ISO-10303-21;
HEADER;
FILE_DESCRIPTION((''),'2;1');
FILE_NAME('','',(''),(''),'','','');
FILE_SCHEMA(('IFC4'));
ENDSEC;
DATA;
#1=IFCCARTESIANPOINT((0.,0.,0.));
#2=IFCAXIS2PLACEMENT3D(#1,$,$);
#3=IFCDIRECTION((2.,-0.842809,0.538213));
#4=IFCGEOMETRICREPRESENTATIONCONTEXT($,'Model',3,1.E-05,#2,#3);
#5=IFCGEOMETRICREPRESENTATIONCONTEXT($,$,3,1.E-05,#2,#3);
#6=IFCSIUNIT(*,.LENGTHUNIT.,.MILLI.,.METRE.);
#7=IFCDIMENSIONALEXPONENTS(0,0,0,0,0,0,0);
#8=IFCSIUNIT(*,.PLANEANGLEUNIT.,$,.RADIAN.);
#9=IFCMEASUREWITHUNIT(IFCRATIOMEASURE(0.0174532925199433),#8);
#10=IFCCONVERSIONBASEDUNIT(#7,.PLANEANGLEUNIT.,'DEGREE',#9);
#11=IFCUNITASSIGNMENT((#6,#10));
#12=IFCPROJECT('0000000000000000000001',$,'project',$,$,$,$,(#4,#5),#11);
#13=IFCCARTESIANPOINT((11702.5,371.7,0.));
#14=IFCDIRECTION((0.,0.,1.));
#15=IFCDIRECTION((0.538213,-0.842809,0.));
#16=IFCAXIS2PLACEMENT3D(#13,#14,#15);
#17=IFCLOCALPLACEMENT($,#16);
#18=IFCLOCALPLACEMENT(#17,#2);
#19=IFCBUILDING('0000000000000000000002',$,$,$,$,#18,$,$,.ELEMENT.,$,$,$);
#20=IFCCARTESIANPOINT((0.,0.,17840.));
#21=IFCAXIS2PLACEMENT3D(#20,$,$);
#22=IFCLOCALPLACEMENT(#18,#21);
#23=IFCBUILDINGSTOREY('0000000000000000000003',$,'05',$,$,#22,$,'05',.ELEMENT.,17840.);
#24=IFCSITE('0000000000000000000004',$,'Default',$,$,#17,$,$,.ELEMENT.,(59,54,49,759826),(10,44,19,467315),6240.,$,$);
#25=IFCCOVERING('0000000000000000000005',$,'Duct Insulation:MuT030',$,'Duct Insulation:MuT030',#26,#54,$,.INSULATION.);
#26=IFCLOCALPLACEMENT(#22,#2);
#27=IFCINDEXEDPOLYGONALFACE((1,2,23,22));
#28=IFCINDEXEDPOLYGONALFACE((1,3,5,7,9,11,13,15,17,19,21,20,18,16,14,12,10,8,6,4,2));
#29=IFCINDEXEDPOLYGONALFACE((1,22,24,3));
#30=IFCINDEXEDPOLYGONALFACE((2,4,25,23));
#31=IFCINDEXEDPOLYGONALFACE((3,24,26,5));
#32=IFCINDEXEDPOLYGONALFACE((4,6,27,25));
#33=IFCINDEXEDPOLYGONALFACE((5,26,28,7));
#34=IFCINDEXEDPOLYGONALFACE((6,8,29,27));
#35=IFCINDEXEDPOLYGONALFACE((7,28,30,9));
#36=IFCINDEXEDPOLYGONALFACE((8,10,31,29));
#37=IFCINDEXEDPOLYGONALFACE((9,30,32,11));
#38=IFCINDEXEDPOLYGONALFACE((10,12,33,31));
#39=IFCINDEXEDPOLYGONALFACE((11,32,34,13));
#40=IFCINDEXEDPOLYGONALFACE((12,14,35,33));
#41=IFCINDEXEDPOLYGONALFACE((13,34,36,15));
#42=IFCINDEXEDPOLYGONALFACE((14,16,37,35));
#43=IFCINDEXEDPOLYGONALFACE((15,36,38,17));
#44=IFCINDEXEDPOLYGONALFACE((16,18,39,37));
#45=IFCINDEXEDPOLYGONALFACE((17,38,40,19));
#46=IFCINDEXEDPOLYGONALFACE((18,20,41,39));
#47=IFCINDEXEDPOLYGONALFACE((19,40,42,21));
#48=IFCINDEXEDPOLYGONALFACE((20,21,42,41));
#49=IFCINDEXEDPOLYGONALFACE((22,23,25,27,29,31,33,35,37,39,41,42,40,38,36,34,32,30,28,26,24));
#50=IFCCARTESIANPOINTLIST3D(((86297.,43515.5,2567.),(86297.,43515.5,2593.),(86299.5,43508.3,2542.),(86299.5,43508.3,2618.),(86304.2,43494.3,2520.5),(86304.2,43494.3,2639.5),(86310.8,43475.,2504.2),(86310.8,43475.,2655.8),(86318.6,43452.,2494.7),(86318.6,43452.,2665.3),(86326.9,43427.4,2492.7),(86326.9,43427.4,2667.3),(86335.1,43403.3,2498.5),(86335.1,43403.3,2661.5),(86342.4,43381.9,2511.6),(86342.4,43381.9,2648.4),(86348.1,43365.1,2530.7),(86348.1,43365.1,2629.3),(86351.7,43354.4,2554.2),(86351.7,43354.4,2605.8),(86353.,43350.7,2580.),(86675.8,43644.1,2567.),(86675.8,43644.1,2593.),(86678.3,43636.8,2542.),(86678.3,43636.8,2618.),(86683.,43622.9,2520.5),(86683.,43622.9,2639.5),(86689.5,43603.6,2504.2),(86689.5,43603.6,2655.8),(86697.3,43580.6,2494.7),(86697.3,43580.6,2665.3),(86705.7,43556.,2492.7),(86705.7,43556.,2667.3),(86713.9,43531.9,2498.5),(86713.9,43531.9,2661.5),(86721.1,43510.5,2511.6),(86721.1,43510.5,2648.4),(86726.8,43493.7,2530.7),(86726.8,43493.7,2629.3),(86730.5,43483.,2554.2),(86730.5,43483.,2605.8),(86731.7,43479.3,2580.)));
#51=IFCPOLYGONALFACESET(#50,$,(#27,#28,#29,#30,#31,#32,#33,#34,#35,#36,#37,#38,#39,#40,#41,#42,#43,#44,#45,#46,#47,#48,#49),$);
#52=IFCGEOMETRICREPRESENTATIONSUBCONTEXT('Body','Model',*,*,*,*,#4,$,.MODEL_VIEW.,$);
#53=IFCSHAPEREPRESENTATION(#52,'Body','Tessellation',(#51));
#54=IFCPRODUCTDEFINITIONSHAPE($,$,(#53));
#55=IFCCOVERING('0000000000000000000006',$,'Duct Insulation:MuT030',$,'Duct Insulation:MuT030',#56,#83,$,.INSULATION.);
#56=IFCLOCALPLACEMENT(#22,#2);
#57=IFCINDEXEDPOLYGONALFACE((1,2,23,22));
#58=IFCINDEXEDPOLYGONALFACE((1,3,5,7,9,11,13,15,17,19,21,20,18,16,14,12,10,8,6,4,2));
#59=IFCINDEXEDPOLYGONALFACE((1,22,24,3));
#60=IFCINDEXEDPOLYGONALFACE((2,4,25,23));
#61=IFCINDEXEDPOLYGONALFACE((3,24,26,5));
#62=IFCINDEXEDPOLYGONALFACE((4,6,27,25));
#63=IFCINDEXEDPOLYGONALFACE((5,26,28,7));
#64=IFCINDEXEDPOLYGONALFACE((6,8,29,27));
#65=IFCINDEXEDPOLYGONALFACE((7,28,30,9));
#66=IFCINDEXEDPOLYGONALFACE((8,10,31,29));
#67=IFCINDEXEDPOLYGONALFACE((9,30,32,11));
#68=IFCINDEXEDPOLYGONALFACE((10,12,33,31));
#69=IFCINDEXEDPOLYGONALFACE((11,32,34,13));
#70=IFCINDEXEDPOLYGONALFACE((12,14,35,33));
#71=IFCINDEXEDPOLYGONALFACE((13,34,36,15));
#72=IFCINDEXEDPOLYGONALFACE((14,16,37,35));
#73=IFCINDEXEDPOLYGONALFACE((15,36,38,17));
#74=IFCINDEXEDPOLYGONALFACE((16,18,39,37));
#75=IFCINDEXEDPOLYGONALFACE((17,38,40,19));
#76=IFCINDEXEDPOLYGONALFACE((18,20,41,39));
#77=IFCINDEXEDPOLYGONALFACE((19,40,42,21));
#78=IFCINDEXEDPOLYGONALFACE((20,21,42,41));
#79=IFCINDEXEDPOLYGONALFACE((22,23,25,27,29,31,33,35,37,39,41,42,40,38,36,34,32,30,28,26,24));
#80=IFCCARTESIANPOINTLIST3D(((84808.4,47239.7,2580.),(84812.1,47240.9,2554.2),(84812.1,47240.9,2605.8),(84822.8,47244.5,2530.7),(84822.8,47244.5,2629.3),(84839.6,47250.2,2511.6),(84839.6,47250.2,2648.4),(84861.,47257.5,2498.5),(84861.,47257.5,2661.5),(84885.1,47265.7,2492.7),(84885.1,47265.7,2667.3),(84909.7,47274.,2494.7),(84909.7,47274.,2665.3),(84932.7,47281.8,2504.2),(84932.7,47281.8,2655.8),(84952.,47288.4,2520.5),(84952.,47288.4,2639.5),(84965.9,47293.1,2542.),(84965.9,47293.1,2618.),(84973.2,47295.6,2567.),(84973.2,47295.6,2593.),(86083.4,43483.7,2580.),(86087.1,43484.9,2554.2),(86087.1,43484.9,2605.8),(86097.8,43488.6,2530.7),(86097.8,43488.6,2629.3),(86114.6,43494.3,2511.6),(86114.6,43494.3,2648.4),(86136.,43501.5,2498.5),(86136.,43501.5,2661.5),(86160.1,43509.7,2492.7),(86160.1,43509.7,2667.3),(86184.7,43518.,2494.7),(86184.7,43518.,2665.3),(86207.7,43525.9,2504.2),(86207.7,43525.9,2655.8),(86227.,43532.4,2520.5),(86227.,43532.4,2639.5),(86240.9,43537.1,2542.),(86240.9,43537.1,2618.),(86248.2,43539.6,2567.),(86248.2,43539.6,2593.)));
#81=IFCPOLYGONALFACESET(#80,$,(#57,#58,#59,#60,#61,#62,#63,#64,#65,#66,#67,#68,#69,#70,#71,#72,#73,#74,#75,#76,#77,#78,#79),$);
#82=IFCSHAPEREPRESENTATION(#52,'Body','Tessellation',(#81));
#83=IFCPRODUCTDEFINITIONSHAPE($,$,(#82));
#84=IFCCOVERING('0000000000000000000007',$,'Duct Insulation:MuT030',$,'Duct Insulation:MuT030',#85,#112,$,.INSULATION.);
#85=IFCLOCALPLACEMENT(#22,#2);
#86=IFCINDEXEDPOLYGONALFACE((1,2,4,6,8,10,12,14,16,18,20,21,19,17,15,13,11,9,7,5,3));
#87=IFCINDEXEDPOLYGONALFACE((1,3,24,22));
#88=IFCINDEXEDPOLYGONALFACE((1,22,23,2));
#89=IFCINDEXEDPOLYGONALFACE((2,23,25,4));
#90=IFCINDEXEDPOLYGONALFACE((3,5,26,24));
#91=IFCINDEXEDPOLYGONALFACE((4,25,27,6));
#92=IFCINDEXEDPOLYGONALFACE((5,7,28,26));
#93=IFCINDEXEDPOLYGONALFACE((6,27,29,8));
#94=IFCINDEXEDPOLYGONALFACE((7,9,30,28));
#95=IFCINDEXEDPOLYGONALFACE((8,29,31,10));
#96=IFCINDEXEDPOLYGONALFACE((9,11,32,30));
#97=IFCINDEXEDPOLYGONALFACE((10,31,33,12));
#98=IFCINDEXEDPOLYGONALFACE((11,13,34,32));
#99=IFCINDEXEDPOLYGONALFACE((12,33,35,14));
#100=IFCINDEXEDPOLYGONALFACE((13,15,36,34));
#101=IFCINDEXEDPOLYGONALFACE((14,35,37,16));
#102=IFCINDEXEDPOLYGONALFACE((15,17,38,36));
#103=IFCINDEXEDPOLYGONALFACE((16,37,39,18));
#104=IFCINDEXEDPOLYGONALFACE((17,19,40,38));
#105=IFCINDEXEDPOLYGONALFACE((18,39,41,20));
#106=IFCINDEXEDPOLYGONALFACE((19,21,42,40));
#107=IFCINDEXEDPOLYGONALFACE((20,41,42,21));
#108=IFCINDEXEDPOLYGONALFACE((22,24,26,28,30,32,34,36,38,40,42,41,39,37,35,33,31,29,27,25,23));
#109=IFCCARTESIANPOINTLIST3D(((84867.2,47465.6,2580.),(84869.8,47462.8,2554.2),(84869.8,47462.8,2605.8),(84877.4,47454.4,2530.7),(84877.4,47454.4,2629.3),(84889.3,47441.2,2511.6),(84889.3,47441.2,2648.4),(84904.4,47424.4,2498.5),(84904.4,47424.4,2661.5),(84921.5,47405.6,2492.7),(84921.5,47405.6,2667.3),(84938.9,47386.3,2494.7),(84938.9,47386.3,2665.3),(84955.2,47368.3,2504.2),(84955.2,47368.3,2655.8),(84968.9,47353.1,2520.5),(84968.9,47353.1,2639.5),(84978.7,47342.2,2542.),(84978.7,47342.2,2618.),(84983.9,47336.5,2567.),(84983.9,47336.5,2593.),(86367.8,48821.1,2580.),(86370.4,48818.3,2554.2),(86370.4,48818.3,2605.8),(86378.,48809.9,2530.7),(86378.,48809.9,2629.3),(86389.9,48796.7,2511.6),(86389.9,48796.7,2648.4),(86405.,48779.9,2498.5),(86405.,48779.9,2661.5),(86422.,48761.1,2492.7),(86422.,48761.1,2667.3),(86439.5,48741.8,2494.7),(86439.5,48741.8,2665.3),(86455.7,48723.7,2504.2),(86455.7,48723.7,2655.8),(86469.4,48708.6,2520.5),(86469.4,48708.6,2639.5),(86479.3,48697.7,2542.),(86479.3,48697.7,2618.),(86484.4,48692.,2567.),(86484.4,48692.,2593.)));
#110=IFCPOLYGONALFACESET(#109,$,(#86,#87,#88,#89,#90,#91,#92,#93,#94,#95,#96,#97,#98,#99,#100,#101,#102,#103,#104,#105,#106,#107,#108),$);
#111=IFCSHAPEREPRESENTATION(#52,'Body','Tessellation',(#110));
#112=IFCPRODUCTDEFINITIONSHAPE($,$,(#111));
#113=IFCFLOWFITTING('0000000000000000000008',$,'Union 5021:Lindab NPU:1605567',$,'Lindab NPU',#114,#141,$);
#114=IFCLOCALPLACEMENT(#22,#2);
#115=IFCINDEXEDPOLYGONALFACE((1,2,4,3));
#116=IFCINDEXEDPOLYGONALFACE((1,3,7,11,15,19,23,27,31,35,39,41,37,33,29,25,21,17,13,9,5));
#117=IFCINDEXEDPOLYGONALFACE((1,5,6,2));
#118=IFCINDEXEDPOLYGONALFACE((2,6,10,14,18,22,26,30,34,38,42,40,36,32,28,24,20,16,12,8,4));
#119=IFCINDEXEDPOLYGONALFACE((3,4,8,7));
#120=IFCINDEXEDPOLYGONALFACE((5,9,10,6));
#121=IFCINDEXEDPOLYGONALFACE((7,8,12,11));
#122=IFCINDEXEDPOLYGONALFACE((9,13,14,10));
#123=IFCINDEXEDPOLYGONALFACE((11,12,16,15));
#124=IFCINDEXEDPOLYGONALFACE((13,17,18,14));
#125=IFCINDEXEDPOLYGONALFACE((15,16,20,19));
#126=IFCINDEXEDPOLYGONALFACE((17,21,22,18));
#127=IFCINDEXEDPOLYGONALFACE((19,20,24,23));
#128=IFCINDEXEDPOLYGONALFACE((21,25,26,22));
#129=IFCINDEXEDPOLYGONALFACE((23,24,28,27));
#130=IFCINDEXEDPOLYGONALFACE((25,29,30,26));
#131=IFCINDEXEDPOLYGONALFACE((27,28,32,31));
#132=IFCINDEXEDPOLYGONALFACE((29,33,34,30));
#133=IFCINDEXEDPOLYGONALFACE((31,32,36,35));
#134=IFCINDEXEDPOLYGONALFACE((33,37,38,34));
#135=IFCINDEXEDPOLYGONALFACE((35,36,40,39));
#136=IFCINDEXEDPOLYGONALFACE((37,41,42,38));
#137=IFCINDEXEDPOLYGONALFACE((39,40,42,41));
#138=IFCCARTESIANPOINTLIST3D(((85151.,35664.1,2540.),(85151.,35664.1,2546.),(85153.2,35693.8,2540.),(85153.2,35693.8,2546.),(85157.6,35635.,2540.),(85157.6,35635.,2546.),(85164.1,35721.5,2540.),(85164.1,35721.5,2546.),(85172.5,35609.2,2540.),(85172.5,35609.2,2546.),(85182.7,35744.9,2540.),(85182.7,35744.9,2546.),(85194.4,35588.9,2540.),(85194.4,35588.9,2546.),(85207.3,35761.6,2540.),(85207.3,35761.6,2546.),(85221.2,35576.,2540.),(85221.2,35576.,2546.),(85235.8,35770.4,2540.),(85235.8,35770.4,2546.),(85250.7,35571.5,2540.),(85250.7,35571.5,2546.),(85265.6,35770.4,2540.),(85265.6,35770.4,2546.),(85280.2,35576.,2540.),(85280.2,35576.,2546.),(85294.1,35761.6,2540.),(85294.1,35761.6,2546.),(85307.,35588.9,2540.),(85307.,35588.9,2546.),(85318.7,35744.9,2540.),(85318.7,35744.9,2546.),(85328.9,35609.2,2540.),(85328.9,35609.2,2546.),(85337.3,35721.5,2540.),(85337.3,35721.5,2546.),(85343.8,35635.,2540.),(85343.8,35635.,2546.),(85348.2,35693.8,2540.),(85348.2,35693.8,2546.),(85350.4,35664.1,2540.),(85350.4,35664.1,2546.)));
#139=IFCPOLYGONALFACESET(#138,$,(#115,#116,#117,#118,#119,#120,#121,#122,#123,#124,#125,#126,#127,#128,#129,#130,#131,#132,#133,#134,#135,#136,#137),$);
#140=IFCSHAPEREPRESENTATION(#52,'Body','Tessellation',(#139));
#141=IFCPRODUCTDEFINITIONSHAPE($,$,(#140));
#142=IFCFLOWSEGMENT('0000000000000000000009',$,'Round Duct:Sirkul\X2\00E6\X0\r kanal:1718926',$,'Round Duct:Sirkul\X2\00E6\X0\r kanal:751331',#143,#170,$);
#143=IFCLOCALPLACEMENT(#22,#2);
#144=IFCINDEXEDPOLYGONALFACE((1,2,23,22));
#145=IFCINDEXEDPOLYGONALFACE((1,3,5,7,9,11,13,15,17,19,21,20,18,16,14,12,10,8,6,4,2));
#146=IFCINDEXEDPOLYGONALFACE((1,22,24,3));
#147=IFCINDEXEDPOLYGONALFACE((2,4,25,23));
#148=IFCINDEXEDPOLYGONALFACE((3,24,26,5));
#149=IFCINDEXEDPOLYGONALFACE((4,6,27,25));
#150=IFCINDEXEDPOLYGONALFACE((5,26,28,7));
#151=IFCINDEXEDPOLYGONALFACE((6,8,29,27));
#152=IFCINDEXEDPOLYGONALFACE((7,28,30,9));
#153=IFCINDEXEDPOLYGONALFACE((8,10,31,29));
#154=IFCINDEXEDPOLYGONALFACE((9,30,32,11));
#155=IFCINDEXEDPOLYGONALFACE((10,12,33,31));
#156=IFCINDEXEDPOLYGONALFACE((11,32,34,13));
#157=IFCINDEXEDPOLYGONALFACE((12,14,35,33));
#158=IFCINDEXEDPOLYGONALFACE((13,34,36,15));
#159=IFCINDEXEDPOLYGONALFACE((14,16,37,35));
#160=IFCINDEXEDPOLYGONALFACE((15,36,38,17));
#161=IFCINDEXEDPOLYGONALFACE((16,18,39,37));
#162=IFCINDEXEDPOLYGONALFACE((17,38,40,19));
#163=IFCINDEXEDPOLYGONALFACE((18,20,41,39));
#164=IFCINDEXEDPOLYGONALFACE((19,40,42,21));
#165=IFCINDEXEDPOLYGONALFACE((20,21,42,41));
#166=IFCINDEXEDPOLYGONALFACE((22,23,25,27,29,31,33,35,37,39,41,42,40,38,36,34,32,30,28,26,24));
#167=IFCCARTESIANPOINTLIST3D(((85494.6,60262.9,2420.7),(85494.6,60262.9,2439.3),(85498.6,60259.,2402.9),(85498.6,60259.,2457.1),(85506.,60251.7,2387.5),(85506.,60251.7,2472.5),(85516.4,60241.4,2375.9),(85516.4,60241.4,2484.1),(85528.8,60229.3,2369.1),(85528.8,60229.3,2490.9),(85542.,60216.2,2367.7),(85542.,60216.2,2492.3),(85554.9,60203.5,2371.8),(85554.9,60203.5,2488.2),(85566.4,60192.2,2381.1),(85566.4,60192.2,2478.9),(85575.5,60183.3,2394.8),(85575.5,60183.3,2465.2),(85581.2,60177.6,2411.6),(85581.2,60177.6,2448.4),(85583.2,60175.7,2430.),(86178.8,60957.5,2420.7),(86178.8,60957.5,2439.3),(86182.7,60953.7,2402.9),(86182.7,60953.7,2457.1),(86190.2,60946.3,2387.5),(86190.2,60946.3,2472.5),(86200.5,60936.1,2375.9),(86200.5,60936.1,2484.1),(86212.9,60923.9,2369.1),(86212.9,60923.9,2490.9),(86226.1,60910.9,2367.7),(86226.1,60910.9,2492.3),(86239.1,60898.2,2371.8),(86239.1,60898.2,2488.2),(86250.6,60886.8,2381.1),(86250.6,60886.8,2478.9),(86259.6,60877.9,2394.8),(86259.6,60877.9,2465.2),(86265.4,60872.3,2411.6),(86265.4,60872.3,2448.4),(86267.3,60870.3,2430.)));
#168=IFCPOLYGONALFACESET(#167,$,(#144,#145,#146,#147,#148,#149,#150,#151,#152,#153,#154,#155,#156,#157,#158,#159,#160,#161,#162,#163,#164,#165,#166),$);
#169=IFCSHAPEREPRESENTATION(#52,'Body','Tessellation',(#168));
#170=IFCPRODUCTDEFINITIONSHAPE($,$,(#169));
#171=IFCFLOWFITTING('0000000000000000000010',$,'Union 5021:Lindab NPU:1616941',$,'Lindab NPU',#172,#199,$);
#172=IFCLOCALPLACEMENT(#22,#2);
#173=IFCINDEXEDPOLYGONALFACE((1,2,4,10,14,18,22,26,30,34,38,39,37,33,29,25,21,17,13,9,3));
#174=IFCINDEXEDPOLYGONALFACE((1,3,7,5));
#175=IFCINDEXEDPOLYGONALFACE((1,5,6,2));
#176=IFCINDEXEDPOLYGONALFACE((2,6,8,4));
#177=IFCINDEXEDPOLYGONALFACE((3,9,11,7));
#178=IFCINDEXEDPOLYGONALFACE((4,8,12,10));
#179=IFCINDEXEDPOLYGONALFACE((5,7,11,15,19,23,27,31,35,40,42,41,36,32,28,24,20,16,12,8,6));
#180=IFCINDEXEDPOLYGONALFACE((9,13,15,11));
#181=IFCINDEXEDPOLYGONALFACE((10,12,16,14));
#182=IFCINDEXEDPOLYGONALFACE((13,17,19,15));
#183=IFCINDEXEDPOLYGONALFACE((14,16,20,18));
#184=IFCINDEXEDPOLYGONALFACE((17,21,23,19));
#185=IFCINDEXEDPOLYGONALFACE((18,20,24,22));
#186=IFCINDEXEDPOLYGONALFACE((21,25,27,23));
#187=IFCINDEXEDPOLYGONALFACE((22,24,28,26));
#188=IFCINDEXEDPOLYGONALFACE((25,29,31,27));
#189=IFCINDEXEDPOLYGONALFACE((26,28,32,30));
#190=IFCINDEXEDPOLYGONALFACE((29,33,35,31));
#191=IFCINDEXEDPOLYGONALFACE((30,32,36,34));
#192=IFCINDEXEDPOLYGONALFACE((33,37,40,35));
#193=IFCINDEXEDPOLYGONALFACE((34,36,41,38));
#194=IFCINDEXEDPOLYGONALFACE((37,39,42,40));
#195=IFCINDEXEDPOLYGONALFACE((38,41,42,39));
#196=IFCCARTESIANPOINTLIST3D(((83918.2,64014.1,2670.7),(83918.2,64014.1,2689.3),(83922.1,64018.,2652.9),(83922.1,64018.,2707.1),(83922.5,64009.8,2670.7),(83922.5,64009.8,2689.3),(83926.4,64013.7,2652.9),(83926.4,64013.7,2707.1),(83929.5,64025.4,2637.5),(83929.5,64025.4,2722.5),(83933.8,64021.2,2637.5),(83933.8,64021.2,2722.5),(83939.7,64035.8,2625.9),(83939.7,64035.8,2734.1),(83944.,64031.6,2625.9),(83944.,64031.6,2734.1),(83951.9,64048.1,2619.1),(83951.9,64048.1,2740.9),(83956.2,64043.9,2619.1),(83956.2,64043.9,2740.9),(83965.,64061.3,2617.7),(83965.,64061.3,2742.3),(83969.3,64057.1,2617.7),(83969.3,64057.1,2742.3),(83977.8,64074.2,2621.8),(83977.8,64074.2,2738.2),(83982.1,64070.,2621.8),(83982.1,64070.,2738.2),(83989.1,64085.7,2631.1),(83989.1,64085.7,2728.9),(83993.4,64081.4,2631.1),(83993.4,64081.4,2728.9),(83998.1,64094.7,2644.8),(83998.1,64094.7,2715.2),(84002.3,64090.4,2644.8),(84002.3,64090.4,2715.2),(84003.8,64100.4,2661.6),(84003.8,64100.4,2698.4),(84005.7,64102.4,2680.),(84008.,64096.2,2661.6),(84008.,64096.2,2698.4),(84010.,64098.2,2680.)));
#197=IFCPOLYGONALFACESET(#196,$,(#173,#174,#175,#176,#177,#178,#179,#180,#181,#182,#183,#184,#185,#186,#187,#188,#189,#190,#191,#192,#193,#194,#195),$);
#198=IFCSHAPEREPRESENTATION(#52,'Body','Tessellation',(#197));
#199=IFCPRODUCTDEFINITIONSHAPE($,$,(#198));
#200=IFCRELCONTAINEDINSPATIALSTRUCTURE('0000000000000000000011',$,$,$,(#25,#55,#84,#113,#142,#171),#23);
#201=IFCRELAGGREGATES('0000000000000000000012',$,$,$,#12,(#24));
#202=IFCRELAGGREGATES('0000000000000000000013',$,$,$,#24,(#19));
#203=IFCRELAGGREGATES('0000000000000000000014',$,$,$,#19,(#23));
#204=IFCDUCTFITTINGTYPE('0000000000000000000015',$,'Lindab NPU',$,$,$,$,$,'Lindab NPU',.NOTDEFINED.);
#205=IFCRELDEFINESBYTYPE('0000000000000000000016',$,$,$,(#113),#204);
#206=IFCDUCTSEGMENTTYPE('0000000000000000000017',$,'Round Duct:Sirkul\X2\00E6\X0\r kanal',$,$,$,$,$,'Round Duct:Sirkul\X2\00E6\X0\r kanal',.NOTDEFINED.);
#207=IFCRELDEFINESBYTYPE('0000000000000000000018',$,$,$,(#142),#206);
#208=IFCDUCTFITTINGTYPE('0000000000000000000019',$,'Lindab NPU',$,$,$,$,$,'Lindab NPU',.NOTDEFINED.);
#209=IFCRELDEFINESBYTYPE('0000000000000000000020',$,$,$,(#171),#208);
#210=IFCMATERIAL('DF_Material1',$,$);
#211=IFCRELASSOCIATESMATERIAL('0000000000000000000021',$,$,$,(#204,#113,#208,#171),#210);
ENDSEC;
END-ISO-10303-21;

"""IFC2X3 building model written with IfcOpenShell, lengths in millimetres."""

from ifc_helpers import new_model, entity, si_unit, converted_unit, direction, frame, frame_2d, origin, origin_2d_with_axis, place, context, subcontext, project, spatial, circle, extrude, source, transform, mapped, material, type_object, type_shapes, element, save


model = new_model("IFC2X3")

# Units and contexts
model_context = context("Model", 3, precision=1e-05, world=origin(), true_north=direction((2.0, -0.842809, 0.538213)))
context_of_model = context(None, 3, precision=1e-05, world=origin(), true_north=direction((2.0, -0.842809, 0.538213)))
body_context = subcontext(model_context, "Body", "Model", "MODEL_VIEW")
ifc_project = project(units=[si_unit("LENGTHUNIT", "METRE", prefix="MILLI"), converted_unit("PLANEANGLEUNIT", "DEGREE", entity("IfcRatioMeasure", 0.0174532925199433), si_unit("PLANEANGLEUNIT", "RADIAN"), dimensions=[0, 0, 0, 0, 0, 0, 0])], contexts=[model_context, context_of_model])

# Site, building, storey
site_placement = place(None, frame((11702.5, 371.7, 0.0), z_axis=(0.0, 0.0, 1.0), x_axis=(0.538213, -0.842809, 0.0)))
site = spatial("IfcSite", under=ifc_project, at=site_placement, Name="Default", CompositionType="ELEMENT", RefLatitude=(59, 54, 49, 759826), RefLongitude=(10, 44, 19, 467315), RefElevation=6240.0)
building_placement = place(site_placement, origin())
building = spatial("IfcBuilding", under=site, at=building_placement, CompositionType="ELEMENT")
storey_placement = place(building_placement, frame((0.0, 0.0, 17840.0)))
storey = spatial("IfcBuildingStorey", under=building, at=storey_placement, Name="05", LongName="05", CompositionType="ELEMENT", Elevation=17840.0)

# Coverings
covering_1_placement = place(storey_placement, origin())
element("IfcCovering", 1, at=covering_1_placement, inside=storey, Name="Duct Insulation:MuT030", ObjectType="Duct Insulation:MuT030", PredefinedType="INSULATION", context=body_context, shape_type="SweptSolid", body=[
    extrude(circle(Radius=87.5, at=origin_2d_with_axis()), frame((86324.8, 43433.6, 2580.0), z_axis=(0.94693, 0.321439, 0.0), x_axis=(0.321439, -0.94693, 0.0)), (0.0, 0.0, 1.0), 400.0),
])
covering_2_placement = place(storey_placement, origin())
element("IfcCovering", 2, at=covering_2_placement, inside=storey, Name="Duct Insulation:MuT030", ObjectType="Duct Insulation:MuT030", PredefinedType="INSULATION", context=body_context, shape_type="SweptSolid", body=[
    extrude(circle(Radius=87.5, at=origin_2d_with_axis()), frame((86166.3, 43511.8, 2580.0), z_axis=(-0.321439, 0.94693, 0.0), x_axis=(-0.94693, -0.321439, 0.0)), (0.0, 0.0, 1.0), 3966.5),
])
covering_3_placement = place(storey_placement, origin())
element("IfcCovering", 3, at=covering_3_placement, inside=storey, Name="Duct Insulation:MuT030", ObjectType="Duct Insulation:MuT030", PredefinedType="INSULATION", context=body_context, shape_type="SweptSolid", body=[
    extrude(circle(Radius=87.5, at=origin_2d_with_axis()), frame((84925.9, 47400.7, 2580.0), z_axis=(0.742063, 0.67033, 0.0), x_axis=(-0.67033, 0.742063, 0.0)), (0.0, 0.0, 1.0), 2022.1),
])

# Flow fitting
ifc_material = material(Name="DF_Material1")
duct_fitting_type_1 = type_object("IfcDuctFittingType", Name="Lindab NPU", ElementType="Lindab NPU", PredefinedType="NOTDEFINED", material=ifc_material)
shared_shape_1 = source(origin(), body_context, "Body", "SweptSolid", [
    extrude(circle(Radius=100.0, at=frame_2d((0.0, 0.0), x_axis=(1.0, 0.0))), frame((0.0, 0.0, 0.0), z_axis=(1.0, 0.0, 0.0), x_axis=(0.0, 1.0, 0.0)), (0.0, 0.0, 1.0), 6.0),
])
type_shapes(duct_fitting_type_1, [shared_shape_1])
flow_fitting_placement = place(storey_placement, frame((85250.7, 35671.5, 2540.0), z_axis=(1.0, 0.0, 0.0), x_axis=(0.0, 0.0, 1.0)))
element("IfcFlowFitting", 4, at=flow_fitting_placement, inside=storey, type_object=duct_fitting_type_1, material=ifc_material, Name="Union 5021:Lindab NPU:1605567", ObjectType="Lindab NPU", context=body_context, shape_type="MappedRepresentation", body=[
    mapped(shared_shape_1, transform((0.0, 0.0, 0.0), scale=1.0)),
])

# Flow segment
duct_segment_type = type_object("IfcDuctSegmentType", Name="Round Duct:Sirkulær kanal", ElementType="Round Duct:Sirkulær kanal", PredefinedType="NOTDEFINED")
flow_segment_1_placement = place(storey_placement, origin())
element("IfcFlowSegment", 5, at=flow_segment_1_placement, inside=storey, type_object=duct_segment_type, Name="Round Duct:Sirkulær kanal:1718926", ObjectType="Round Duct:Sirkulær kanal:751331", context=body_context, shape_type="SweptSolid", body=[
    extrude(circle(Radius=62.5, at=origin_2d_with_axis()), frame((85538.7, 60219.5, 2430.0), z_axis=(0.701682, 0.71249, 0.0), x_axis=(0.71249, -0.701682, 0.0)), (0.0, 0.0, 1.0), 975.0),
])

# Flow fitting
duct_fitting_type_2 = type_object("IfcDuctFittingType", Name="Lindab NPU", ElementType="Lindab NPU", PredefinedType="NOTDEFINED", material=ifc_material)
shared_shape_2 = source(origin(), body_context, "Body", "SweptSolid", [
    extrude(circle(Radius=62.5, at=frame_2d((0.0, 0.0), x_axis=(1.0, 0.0))), frame((0.0, 0.0, 0.0), z_axis=(1.0, 0.0, 0.0), x_axis=(0.0, 1.0, 0.0)), (0.0, 0.0, 1.0), 6.0),
])
type_shapes(duct_fitting_type_2, [shared_shape_2])
for number, where, z_axis, x_axis, name in (
    (6, (83961.7, 64058.0, 2680.0), (0.0, 0.0, 1.0), (0.710528, -0.703669, 0.0), "Union 5021:Lindab NPU:1616941"),
):
    element("IfcFlowFitting", number, at=place(storey_placement, frame(where, z_axis=z_axis, x_axis=x_axis)), inside=storey, type_object=duct_fitting_type_2, material=ifc_material, Name=name, ObjectType="Lindab NPU", context=body_context, shape_type="MappedRepresentation", body=[
        mapped(shared_shape_2, transform((0.0, 0.0, 0.0), scale=1.0)),
    ])

save(model, "model.ifc")
